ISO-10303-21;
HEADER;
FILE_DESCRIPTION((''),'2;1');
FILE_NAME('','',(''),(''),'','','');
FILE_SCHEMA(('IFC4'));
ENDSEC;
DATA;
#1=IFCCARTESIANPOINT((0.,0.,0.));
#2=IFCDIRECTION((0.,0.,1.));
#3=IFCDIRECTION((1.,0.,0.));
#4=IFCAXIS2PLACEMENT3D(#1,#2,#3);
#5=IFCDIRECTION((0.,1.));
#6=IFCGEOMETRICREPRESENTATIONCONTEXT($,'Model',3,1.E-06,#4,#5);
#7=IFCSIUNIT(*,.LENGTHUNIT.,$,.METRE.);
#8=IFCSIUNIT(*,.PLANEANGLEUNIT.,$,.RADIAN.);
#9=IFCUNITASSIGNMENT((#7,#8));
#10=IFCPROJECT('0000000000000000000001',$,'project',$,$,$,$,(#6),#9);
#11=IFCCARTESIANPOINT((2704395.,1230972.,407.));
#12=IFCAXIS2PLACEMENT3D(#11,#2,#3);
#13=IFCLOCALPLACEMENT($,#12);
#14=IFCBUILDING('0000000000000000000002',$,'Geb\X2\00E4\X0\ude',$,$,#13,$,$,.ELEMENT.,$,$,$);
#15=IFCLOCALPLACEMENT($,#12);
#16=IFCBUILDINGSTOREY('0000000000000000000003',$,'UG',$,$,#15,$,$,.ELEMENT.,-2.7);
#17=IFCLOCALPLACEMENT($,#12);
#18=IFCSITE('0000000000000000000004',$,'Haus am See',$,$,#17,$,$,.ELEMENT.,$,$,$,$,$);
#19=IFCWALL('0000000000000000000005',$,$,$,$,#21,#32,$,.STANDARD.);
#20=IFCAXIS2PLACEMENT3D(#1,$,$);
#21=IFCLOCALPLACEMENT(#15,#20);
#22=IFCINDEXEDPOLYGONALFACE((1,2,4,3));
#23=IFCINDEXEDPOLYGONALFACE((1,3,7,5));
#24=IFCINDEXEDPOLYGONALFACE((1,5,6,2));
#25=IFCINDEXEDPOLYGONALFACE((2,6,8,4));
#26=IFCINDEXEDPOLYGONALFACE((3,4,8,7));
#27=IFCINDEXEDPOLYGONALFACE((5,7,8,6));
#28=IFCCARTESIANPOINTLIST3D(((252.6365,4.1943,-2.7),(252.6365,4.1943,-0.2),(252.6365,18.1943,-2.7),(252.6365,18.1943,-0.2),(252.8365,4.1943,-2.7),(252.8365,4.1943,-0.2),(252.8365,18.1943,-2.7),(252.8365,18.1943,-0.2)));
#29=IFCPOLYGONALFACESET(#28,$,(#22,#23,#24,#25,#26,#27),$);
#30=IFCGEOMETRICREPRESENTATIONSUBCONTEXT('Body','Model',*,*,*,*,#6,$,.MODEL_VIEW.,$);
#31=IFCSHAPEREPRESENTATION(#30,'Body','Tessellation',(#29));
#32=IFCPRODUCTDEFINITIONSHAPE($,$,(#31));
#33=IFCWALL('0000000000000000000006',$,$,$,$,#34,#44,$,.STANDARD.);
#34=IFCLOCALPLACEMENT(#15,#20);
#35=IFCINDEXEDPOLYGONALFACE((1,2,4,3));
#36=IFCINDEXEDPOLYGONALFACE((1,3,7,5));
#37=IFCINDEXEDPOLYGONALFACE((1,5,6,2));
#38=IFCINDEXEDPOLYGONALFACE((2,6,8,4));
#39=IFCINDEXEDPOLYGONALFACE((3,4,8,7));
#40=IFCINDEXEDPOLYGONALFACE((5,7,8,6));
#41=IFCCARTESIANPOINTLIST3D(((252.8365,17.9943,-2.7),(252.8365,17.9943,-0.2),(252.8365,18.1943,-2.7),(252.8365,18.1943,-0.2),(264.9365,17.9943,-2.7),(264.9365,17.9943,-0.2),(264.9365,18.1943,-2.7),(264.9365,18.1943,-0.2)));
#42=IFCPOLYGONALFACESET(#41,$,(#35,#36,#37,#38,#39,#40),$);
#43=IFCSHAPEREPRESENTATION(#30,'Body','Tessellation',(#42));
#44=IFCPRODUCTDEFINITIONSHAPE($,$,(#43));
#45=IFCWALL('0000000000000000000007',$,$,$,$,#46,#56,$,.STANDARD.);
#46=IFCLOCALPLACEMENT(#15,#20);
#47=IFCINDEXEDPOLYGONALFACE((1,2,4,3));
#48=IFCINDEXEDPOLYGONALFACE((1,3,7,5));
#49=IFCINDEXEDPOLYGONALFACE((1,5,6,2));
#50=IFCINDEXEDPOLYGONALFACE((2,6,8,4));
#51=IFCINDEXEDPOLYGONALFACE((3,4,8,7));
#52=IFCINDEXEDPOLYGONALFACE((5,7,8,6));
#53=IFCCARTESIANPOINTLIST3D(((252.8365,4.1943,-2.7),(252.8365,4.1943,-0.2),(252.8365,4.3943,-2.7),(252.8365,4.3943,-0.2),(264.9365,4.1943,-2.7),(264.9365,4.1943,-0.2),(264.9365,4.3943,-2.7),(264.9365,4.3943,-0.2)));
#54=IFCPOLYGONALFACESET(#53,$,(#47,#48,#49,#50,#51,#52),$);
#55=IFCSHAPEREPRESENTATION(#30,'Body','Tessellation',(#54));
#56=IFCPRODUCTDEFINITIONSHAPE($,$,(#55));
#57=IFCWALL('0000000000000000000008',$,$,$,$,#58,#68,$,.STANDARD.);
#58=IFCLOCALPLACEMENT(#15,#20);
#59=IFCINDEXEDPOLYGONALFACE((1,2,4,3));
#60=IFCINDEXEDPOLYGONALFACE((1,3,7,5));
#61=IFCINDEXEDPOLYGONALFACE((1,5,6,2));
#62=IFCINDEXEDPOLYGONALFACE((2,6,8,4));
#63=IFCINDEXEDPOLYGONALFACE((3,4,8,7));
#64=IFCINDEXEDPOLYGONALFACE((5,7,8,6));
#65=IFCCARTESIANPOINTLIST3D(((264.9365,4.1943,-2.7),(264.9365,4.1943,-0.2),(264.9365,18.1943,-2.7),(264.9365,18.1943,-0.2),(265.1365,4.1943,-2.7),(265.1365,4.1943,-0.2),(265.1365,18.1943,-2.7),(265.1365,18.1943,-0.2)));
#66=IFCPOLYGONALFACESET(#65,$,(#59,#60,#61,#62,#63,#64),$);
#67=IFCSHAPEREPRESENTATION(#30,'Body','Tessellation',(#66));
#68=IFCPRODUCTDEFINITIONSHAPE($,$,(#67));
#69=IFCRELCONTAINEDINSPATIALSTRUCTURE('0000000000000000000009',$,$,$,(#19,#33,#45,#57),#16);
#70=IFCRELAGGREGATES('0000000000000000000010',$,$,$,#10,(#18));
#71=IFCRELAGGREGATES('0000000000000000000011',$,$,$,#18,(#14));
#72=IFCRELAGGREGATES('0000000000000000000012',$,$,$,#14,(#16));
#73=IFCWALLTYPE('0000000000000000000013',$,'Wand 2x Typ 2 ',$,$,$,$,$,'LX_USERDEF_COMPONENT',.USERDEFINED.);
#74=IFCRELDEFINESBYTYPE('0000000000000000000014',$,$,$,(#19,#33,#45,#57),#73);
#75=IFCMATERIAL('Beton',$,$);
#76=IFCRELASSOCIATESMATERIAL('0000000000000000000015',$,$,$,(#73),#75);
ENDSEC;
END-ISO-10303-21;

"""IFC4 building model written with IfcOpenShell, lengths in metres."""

from ifc_helpers import new_model, si_unit, direction, frame, origin_with_axes, place, context, subcontext, project, spatial, polyline, outline, extrude, material, type_object, element, save


model = new_model("IFC4")

# Units and contexts
model_context = context("Model", 3, precision=1e-06, world=origin_with_axes(), true_north=direction((0.0, 1.0)))
body_context = subcontext(model_context, "Body", "Model", "MODEL_VIEW")
ifc_project = project(units=[si_unit("LENGTHUNIT", "METRE"), si_unit("PLANEANGLEUNIT", "RADIAN")], contexts=[model_context])

# Site, building, storey
site_placement = place(None, frame((2704395.0, 1230972.0, 407.0), z_axis=(0.0, 0.0, 1.0), x_axis=(1.0, 0.0, 0.0)))
site = spatial("IfcSite", under=ifc_project, at=site_placement, Name="Haus am See", CompositionType="ELEMENT")
building_placement = place(None, frame((2704395.0, 1230972.0, 407.0), z_axis=(0.0, 0.0, 1.0), x_axis=(1.0, 0.0, 0.0)))
building = spatial("IfcBuilding", under=site, at=building_placement, Name="Gebäude", CompositionType="ELEMENT")
storey_placement = place(None, frame((2704395.0, 1230972.0, 407.0), z_axis=(0.0, 0.0, 1.0), x_axis=(1.0, 0.0, 0.0)))
storey = spatial("IfcBuildingStorey", under=building, at=storey_placement, Name="UG", CompositionType="ELEMENT", Elevation=-2.7)

# Walls
ifc_material_1 = material(Name="Beton")
wall_type = type_object("IfcWallType", Name="Wand 2x Typ 2 ", ElementType="LX_USERDEF_COMPONENT", PredefinedType="USERDEFINED", material=ifc_material_1)
wall_1_placement = place(storey_placement, frame((252.6365, 18.1943, -2.7), z_axis=(0.0, 0.0, 1.0), x_axis=(0.0, -1.0, 0.0)))
element("IfcWall", 1, at=wall_1_placement, inside=storey, type_object=wall_type, PredefinedType="STANDARD", context=body_context, shape_type="SweptSolid", body=[
    extrude(outline(polyline([(0.0, 0.0, 0.0), (14.0, 0.0, 0.0), (14.0, 0.2, 0.0), (0.0, 0.2, 0.0), (0.0, 0.0, 0.0)])), origin_with_axes(), (0.0, 0.0, 1.0), 2.5),
])
wall_2_placement = place(storey_placement, frame((264.9365, 18.1943, -2.7), z_axis=(0.0, 0.0, 1.0), x_axis=(-1.0, 0.0, 0.0)))
element("IfcWall", 2, at=wall_2_placement, inside=storey, type_object=wall_type, PredefinedType="STANDARD", context=body_context, shape_type="SweptSolid", body=[
    extrude(outline(polyline([(0.0, 0.0, 0.0), (12.1, 0.0, 0.0), (12.1, 0.2, 0.0), (0.0, 0.2, 0.0), (0.0, 0.0, 0.0)])), origin_with_axes(), (0.0, 0.0, 1.0), 2.5),
])
wall_3_placement = place(storey_placement, frame((252.8365, 4.1943, -2.7), z_axis=(0.0, 0.0, 1.0), x_axis=(1.0, 0.0, 0.0)))
element("IfcWall", 3, at=wall_3_placement, inside=storey, type_object=wall_type, PredefinedType="STANDARD", context=body_context, shape_type="SweptSolid", body=[
    extrude(outline(polyline([(0.0, 0.0, 0.0), (12.1, 0.0, 0.0), (12.1, 0.2, 0.0), (0.0, 0.2, 0.0), (0.0, 0.0, 0.0)])), origin_with_axes(), (0.0, 0.0, 1.0), 2.5),
])
wall_4_placement = place(storey_placement, frame((265.1365, 4.1943, -2.7), z_axis=(0.0, 0.0, 1.0), x_axis=(0.0, 1.0, 0.0)))
element("IfcWall", 4, at=wall_4_placement, inside=storey, type_object=wall_type, PredefinedType="STANDARD", context=body_context, shape_type="SweptSolid", body=[
    extrude(outline(polyline([(0.0, 0.0, 0.0), (14.0, 0.0, 0.0), (14.0, 0.2, 0.0), (0.0, 0.2, 0.0), (0.0, 0.0, 0.0)])), origin_with_axes(), (0.0, 0.0, 1.0), 2.5),
])

save(model, "model.ifc")
